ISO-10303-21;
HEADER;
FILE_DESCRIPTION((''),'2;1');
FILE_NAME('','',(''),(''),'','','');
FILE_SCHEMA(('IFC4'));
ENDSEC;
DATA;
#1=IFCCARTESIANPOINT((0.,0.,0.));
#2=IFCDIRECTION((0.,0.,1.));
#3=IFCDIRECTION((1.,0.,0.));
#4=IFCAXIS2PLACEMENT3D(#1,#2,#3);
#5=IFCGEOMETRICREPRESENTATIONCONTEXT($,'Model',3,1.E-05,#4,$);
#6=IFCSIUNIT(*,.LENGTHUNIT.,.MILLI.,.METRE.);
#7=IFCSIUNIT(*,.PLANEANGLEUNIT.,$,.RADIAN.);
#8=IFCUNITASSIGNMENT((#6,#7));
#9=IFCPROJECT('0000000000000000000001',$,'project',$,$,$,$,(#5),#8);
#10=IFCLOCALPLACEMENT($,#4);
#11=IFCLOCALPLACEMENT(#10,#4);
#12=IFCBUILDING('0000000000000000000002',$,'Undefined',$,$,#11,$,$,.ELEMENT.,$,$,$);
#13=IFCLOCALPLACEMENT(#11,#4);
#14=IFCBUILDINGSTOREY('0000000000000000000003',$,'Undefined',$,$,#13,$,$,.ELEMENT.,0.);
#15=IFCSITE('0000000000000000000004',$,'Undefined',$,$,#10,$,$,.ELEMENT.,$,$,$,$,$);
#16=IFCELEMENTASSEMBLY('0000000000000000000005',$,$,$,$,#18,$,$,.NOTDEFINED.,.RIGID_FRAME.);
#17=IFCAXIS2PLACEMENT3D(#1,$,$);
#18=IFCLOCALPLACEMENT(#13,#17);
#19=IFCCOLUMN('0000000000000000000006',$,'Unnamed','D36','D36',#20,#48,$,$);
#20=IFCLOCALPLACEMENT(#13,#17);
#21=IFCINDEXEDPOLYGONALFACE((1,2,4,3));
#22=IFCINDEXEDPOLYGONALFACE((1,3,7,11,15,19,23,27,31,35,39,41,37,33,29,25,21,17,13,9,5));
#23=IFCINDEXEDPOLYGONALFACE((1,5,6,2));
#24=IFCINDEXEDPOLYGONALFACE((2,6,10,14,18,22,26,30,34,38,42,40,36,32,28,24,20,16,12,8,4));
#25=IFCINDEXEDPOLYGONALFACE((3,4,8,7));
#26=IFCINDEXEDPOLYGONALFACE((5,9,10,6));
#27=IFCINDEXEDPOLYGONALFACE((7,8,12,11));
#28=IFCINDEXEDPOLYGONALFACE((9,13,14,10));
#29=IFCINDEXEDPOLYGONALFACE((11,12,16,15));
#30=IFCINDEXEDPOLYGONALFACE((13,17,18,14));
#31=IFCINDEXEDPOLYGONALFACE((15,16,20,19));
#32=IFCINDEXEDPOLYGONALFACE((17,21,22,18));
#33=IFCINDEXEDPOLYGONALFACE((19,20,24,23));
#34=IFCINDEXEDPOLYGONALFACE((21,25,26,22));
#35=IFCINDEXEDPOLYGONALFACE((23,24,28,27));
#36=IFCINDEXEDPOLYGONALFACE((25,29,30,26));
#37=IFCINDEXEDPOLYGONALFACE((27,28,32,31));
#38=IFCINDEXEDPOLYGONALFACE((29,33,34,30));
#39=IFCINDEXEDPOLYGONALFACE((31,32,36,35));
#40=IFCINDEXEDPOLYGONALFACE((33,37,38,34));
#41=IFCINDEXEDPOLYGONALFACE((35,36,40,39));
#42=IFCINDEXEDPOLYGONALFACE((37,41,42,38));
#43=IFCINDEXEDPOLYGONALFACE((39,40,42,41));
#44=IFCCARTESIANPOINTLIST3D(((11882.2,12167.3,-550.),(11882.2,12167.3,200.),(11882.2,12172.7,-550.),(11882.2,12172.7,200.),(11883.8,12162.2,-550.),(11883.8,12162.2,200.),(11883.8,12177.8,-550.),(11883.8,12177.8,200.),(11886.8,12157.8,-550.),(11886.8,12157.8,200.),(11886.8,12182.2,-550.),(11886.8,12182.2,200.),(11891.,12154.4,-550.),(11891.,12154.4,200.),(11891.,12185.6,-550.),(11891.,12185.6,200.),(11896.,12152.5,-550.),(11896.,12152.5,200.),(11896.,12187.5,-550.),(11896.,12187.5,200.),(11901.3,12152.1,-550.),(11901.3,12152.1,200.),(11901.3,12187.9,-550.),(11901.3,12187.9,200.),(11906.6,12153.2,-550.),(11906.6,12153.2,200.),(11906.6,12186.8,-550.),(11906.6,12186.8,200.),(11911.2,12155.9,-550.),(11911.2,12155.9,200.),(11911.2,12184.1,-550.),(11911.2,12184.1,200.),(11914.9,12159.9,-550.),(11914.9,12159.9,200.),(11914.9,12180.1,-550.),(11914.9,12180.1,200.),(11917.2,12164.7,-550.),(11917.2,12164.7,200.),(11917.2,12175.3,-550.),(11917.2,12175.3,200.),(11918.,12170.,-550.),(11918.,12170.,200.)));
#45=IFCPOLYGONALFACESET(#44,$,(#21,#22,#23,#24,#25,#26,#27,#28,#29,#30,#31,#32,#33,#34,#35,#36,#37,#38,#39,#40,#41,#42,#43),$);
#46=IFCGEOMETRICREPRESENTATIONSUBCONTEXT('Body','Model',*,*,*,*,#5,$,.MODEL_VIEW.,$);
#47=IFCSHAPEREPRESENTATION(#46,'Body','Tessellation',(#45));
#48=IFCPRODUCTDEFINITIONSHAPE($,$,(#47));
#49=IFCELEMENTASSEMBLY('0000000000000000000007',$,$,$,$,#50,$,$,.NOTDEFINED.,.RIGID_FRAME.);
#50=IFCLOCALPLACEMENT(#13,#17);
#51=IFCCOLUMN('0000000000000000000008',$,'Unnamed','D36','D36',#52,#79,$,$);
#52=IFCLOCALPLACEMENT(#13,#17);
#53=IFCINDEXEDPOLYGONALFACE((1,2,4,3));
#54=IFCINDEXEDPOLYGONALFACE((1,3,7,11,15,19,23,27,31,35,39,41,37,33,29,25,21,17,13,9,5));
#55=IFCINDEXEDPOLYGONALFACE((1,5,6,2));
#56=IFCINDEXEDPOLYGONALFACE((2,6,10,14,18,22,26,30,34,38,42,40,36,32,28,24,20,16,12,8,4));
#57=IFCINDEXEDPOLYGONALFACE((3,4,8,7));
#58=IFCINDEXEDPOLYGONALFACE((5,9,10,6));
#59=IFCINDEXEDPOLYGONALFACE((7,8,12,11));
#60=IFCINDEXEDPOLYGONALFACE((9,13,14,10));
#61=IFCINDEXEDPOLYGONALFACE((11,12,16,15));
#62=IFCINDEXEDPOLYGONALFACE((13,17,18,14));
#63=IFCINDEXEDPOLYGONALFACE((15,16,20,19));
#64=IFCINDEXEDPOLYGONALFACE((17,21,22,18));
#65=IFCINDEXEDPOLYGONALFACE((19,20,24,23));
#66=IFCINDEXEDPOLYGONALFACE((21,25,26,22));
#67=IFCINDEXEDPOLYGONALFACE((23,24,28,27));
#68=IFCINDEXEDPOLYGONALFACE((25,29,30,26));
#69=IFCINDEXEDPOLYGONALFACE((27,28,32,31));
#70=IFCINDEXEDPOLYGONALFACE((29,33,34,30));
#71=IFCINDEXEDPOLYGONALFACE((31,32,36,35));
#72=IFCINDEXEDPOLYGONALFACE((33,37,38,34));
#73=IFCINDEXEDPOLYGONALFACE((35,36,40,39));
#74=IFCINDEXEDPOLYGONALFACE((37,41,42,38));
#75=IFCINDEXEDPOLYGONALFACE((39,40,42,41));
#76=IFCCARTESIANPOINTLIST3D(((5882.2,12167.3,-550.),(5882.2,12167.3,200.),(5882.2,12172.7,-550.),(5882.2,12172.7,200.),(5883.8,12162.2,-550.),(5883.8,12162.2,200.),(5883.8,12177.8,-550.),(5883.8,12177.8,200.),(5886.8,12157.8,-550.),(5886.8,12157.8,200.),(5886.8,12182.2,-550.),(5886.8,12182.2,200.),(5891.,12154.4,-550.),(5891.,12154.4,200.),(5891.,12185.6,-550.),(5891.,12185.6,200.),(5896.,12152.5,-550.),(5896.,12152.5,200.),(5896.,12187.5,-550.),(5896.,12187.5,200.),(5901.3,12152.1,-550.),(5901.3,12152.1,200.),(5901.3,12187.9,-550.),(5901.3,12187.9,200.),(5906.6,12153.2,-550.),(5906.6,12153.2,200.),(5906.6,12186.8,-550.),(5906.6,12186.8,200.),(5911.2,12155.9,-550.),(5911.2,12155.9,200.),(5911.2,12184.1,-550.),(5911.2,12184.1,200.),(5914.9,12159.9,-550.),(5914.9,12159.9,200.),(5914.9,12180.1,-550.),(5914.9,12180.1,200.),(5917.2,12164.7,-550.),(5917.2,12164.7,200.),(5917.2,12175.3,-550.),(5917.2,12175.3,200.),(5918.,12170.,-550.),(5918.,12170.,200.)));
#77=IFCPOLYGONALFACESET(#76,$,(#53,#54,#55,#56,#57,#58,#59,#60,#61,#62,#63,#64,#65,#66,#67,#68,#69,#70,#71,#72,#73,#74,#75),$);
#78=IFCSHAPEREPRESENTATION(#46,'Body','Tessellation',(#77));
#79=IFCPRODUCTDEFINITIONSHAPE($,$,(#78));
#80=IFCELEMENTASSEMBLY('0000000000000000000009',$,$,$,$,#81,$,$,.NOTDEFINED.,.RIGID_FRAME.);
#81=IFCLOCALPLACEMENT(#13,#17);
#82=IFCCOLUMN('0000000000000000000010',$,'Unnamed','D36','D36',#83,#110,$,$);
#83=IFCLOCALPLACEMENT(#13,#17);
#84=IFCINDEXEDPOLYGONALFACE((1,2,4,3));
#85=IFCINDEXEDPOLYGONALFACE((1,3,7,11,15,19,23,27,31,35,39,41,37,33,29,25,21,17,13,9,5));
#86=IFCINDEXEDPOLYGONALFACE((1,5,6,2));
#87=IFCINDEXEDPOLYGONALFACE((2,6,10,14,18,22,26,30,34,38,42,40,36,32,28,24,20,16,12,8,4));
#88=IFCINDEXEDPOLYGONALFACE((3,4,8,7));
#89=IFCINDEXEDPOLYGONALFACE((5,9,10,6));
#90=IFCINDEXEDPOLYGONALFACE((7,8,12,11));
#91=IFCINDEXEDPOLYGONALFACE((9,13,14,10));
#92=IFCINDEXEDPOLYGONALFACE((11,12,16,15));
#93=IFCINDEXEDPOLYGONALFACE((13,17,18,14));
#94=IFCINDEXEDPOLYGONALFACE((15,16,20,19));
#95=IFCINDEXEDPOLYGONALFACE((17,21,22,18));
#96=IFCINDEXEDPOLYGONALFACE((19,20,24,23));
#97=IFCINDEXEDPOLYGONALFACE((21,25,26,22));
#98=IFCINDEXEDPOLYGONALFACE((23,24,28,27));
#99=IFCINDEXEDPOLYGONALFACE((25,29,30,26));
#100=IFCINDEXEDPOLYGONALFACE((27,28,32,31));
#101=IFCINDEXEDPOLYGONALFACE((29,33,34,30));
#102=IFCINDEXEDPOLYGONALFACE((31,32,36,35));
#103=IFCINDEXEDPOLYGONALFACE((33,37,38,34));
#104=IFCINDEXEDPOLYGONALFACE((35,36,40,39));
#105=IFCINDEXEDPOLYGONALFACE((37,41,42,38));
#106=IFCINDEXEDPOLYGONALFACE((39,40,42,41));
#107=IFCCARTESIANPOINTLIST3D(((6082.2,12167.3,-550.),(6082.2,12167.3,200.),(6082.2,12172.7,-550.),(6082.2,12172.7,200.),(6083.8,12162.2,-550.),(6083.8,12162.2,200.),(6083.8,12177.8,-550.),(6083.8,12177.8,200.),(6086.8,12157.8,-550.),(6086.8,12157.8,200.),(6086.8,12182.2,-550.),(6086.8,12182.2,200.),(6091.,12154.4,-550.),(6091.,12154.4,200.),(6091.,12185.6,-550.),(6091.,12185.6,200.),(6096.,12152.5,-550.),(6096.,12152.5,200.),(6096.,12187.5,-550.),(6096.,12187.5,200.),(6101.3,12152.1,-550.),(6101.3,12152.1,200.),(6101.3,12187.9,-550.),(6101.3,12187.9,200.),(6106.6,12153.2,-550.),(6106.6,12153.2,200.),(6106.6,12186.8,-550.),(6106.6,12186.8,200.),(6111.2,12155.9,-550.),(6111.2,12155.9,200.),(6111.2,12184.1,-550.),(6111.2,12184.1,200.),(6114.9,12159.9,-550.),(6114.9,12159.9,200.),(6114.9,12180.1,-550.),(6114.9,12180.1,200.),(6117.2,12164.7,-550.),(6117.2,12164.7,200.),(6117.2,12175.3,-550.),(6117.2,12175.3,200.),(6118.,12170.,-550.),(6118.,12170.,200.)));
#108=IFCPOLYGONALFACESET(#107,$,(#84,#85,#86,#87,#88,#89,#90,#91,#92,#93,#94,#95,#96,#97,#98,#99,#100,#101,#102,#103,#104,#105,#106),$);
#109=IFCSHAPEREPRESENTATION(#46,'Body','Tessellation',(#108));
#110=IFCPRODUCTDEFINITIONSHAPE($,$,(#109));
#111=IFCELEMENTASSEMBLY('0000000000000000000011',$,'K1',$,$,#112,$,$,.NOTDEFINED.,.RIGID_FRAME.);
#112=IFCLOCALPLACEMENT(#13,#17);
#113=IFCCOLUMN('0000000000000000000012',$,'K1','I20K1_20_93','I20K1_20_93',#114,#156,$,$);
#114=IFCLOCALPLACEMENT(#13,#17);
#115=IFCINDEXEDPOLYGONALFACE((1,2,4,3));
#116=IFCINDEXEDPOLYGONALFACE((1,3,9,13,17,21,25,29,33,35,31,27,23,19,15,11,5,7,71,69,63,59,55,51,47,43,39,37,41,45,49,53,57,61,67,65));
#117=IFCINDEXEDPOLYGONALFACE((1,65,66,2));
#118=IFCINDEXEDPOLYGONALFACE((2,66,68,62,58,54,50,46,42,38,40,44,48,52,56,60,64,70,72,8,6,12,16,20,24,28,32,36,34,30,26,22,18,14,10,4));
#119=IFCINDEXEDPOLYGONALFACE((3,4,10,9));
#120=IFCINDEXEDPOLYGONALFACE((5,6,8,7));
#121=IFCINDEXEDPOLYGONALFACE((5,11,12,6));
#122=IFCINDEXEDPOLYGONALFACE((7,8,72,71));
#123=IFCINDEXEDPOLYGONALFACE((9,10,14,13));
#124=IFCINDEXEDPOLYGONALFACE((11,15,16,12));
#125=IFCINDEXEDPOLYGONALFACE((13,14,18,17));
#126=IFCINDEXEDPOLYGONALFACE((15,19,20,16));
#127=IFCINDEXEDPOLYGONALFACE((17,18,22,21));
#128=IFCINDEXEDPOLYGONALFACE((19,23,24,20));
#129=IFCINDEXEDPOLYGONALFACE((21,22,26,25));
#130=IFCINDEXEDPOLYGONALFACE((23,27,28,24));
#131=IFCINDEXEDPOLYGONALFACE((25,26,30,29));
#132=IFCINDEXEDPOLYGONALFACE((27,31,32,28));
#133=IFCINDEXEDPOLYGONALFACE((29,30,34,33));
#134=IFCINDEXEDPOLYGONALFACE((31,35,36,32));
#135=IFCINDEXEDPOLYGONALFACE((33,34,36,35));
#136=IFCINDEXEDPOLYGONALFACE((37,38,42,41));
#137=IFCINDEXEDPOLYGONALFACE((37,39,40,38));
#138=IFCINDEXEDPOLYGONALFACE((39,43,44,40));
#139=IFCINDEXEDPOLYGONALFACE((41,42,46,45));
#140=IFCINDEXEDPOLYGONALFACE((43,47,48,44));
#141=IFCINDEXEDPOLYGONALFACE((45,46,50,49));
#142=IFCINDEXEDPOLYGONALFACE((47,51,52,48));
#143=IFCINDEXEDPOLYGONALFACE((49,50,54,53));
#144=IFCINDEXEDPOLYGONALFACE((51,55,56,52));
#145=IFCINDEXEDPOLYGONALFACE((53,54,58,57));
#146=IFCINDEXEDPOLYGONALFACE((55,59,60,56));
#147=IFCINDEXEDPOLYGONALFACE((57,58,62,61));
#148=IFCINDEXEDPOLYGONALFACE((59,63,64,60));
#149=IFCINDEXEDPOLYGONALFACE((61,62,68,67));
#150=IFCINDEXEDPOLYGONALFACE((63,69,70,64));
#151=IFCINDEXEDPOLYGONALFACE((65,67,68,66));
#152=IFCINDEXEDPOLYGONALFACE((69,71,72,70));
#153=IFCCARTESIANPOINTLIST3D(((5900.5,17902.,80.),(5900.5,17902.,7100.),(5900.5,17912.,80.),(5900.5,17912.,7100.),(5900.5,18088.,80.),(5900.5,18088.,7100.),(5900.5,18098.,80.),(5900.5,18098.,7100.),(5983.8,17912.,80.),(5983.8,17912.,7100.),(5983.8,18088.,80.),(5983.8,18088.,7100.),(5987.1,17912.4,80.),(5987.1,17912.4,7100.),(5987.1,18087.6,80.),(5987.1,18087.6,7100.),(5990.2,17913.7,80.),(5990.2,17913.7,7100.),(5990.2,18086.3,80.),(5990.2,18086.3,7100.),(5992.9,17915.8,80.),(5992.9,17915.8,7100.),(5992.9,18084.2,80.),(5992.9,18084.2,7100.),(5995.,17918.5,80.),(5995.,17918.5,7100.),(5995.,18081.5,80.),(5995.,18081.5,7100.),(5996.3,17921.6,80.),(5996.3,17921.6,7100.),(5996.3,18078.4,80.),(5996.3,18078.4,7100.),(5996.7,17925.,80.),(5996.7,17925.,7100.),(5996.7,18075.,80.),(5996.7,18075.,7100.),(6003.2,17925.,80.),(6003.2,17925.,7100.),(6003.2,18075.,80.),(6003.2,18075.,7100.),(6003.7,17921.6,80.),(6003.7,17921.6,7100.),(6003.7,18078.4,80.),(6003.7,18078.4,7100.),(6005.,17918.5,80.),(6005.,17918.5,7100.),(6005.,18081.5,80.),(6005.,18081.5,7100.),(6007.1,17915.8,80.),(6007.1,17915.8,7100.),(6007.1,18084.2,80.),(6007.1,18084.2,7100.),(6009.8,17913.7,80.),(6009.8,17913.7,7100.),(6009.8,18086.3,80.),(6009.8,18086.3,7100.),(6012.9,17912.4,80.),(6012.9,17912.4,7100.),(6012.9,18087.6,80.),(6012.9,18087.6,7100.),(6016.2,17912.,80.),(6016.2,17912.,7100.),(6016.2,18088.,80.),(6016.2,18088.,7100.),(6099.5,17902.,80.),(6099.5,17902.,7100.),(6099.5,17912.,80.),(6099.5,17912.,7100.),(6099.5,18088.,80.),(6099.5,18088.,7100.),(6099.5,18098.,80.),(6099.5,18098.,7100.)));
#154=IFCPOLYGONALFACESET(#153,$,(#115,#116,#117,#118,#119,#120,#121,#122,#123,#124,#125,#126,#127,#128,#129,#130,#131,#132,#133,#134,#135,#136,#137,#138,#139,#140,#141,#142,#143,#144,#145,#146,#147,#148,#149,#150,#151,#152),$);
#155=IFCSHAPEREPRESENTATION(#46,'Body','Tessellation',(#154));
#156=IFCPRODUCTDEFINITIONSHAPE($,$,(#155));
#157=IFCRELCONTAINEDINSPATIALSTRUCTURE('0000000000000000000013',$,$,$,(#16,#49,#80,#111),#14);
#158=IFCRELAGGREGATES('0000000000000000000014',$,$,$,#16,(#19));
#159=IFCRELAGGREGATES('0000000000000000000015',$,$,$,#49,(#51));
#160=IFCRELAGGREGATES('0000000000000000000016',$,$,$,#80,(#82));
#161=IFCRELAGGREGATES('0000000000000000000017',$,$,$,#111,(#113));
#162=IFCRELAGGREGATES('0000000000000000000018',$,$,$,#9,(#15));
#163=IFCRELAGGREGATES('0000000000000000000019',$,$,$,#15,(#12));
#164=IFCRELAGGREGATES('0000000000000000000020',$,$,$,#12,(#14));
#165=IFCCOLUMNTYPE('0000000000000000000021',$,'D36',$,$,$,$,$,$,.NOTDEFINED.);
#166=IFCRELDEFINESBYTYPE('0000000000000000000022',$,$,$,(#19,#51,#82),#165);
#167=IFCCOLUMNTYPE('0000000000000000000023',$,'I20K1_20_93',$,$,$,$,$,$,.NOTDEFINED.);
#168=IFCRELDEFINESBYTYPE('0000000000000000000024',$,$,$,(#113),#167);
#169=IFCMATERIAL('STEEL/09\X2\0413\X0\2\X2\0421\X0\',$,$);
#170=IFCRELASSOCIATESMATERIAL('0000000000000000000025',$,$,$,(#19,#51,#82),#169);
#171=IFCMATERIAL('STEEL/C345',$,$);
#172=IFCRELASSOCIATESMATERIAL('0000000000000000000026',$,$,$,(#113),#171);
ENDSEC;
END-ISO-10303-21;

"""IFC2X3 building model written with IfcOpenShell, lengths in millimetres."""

from ifc_helpers import new_model, si_unit, frame, origin_with_axes, origin_2d_with_axis, place, context, subcontext, project, spatial, circle, i_section, extrude, material, type_object, element, aggregate, save


model = new_model("IFC2X3")

# Units and contexts
model_context = context("Model", 3, precision=1e-05, world=origin_with_axes())
body_context = subcontext(model_context, "Body", "Model", "MODEL_VIEW")
ifc_project = project(units=[si_unit("LENGTHUNIT", "METRE", prefix="MILLI"), si_unit("PLANEANGLEUNIT", "RADIAN")], contexts=[model_context])

# Site, building, storey
site_placement = place(None, origin_with_axes())
site = spatial("IfcSite", under=ifc_project, at=site_placement, Name="Undefined", CompositionType="ELEMENT")
building_placement = place(site_placement, origin_with_axes())
building = spatial("IfcBuilding", under=site, at=building_placement, Name="Undefined", CompositionType="ELEMENT")
storey_placement = place(building_placement, origin_with_axes())
storey = spatial("IfcBuildingStorey", under=building, at=storey_placement, Name="Undefined", CompositionType="ELEMENT", Elevation=0.0)

# Element assemblies, columns
ifc_material_1 = material(Name="STEEL/09Г2С")
column_type_1 = type_object("IfcColumnType", Name="D36", PredefinedType="NOTDEFINED")
assembly_1_placement = place(storey_placement, origin_with_axes())
assembly_1 = element("IfcElementAssembly", 1, at=assembly_1_placement, inside=storey, AssemblyPlace="NOTDEFINED", PredefinedType="RIGID_FRAME")
column_1_placement = place(assembly_1_placement, frame((11900.0, 12170.0, -550.0), z_axis=(0.0, 0.0, 1.0), x_axis=(0.0, -1.0, 0.0)))
column_1 = element("IfcColumn", 2, at=column_1_placement, type_object=column_type_1, material=ifc_material_1, Name="Unnamed", Description="D36", ObjectType="D36", context=body_context, shape_type="SweptSolid", body=[
    extrude(circle(Radius=18.0, at=origin_2d_with_axis()), frame((0.0, 0.0, 750.0), z_axis=(0.0, 0.0, -1.0), x_axis=(0.0, 1.0, 0.0)), (0.0, 0.0, 1.0), 750.0),
])
aggregate(assembly_1, [column_1])
assembly_2_placement = place(storey_placement, origin_with_axes())
assembly_2 = element("IfcElementAssembly", 3, at=assembly_2_placement, inside=storey, AssemblyPlace="NOTDEFINED", PredefinedType="RIGID_FRAME")
column_2_placement = place(assembly_2_placement, frame((5900.0, 12170.0, -550.0), z_axis=(0.0, 0.0, 1.0), x_axis=(0.0, -1.0, 0.0)))
column_2 = element("IfcColumn", 4, at=column_2_placement, type_object=column_type_1, material=ifc_material_1, Name="Unnamed", Description="D36", ObjectType="D36", context=body_context, shape_type="SweptSolid", body=[
    extrude(circle(Radius=18.0, at=origin_2d_with_axis()), frame((0.0, 0.0, 750.0), z_axis=(0.0, 0.0, -1.0), x_axis=(0.0, 1.0, 0.0)), (0.0, 0.0, 1.0), 750.0),
])
aggregate(assembly_2, [column_2])
assembly_3_placement = place(storey_placement, origin_with_axes())
assembly_3 = element("IfcElementAssembly", 5, at=assembly_3_placement, inside=storey, AssemblyPlace="NOTDEFINED", PredefinedType="RIGID_FRAME")
column_3_placement = place(assembly_3_placement, frame((6100.0, 12170.0, -550.0), z_axis=(0.0, 0.0, 1.0), x_axis=(0.0, -1.0, 0.0)))
column_3 = element("IfcColumn", 6, at=column_3_placement, type_object=column_type_1, material=ifc_material_1, Name="Unnamed", Description="D36", ObjectType="D36", context=body_context, shape_type="SweptSolid", body=[
    extrude(circle(Radius=18.0, at=origin_2d_with_axis()), frame((0.0, 0.0, 750.0), z_axis=(0.0, 0.0, -1.0), x_axis=(0.0, 1.0, 0.0)), (0.0, 0.0, 1.0), 750.0),
])
aggregate(assembly_3, [column_3])
assembly_4_placement = place(storey_placement, origin_with_axes())
assembly_4 = element("IfcElementAssembly", 7, at=assembly_4_placement, inside=storey, Name="K1", AssemblyPlace="NOTDEFINED", PredefinedType="RIGID_FRAME")
ifc_material_2 = material(Name="STEEL/C345")
column_type_2 = type_object("IfcColumnType", Name="I20K1_20_93", PredefinedType="NOTDEFINED")
column_4_placement = place(assembly_4_placement, frame((6000.0, 18000.0, 80.0), z_axis=(0.0, 0.0, 1.0), x_axis=(0.0, 1.0, 0.0)))
column_4 = element("IfcColumn", 8, at=column_4_placement, type_object=column_type_2, material=ifc_material_2, Name="K1", Description="I20K1_20_93", ObjectType="I20K1_20_93", context=body_context, shape_type="SweptSolid", body=[
    extrude(i_section(OverallWidth=199.0, OverallDepth=196.0, WebThickness=6.5, FlangeThickness=10.0, FilletRadius=13.0, at=origin_2d_with_axis()), frame((0.0, 0.0, 7020.0), z_axis=(0.0, 0.0, -1.0), x_axis=(0.0, 1.0, 0.0)), (0.0, 0.0, 1.0), 7020.0),
])

aggregate(assembly_4, [column_4])

save(model, "model.ifc")
